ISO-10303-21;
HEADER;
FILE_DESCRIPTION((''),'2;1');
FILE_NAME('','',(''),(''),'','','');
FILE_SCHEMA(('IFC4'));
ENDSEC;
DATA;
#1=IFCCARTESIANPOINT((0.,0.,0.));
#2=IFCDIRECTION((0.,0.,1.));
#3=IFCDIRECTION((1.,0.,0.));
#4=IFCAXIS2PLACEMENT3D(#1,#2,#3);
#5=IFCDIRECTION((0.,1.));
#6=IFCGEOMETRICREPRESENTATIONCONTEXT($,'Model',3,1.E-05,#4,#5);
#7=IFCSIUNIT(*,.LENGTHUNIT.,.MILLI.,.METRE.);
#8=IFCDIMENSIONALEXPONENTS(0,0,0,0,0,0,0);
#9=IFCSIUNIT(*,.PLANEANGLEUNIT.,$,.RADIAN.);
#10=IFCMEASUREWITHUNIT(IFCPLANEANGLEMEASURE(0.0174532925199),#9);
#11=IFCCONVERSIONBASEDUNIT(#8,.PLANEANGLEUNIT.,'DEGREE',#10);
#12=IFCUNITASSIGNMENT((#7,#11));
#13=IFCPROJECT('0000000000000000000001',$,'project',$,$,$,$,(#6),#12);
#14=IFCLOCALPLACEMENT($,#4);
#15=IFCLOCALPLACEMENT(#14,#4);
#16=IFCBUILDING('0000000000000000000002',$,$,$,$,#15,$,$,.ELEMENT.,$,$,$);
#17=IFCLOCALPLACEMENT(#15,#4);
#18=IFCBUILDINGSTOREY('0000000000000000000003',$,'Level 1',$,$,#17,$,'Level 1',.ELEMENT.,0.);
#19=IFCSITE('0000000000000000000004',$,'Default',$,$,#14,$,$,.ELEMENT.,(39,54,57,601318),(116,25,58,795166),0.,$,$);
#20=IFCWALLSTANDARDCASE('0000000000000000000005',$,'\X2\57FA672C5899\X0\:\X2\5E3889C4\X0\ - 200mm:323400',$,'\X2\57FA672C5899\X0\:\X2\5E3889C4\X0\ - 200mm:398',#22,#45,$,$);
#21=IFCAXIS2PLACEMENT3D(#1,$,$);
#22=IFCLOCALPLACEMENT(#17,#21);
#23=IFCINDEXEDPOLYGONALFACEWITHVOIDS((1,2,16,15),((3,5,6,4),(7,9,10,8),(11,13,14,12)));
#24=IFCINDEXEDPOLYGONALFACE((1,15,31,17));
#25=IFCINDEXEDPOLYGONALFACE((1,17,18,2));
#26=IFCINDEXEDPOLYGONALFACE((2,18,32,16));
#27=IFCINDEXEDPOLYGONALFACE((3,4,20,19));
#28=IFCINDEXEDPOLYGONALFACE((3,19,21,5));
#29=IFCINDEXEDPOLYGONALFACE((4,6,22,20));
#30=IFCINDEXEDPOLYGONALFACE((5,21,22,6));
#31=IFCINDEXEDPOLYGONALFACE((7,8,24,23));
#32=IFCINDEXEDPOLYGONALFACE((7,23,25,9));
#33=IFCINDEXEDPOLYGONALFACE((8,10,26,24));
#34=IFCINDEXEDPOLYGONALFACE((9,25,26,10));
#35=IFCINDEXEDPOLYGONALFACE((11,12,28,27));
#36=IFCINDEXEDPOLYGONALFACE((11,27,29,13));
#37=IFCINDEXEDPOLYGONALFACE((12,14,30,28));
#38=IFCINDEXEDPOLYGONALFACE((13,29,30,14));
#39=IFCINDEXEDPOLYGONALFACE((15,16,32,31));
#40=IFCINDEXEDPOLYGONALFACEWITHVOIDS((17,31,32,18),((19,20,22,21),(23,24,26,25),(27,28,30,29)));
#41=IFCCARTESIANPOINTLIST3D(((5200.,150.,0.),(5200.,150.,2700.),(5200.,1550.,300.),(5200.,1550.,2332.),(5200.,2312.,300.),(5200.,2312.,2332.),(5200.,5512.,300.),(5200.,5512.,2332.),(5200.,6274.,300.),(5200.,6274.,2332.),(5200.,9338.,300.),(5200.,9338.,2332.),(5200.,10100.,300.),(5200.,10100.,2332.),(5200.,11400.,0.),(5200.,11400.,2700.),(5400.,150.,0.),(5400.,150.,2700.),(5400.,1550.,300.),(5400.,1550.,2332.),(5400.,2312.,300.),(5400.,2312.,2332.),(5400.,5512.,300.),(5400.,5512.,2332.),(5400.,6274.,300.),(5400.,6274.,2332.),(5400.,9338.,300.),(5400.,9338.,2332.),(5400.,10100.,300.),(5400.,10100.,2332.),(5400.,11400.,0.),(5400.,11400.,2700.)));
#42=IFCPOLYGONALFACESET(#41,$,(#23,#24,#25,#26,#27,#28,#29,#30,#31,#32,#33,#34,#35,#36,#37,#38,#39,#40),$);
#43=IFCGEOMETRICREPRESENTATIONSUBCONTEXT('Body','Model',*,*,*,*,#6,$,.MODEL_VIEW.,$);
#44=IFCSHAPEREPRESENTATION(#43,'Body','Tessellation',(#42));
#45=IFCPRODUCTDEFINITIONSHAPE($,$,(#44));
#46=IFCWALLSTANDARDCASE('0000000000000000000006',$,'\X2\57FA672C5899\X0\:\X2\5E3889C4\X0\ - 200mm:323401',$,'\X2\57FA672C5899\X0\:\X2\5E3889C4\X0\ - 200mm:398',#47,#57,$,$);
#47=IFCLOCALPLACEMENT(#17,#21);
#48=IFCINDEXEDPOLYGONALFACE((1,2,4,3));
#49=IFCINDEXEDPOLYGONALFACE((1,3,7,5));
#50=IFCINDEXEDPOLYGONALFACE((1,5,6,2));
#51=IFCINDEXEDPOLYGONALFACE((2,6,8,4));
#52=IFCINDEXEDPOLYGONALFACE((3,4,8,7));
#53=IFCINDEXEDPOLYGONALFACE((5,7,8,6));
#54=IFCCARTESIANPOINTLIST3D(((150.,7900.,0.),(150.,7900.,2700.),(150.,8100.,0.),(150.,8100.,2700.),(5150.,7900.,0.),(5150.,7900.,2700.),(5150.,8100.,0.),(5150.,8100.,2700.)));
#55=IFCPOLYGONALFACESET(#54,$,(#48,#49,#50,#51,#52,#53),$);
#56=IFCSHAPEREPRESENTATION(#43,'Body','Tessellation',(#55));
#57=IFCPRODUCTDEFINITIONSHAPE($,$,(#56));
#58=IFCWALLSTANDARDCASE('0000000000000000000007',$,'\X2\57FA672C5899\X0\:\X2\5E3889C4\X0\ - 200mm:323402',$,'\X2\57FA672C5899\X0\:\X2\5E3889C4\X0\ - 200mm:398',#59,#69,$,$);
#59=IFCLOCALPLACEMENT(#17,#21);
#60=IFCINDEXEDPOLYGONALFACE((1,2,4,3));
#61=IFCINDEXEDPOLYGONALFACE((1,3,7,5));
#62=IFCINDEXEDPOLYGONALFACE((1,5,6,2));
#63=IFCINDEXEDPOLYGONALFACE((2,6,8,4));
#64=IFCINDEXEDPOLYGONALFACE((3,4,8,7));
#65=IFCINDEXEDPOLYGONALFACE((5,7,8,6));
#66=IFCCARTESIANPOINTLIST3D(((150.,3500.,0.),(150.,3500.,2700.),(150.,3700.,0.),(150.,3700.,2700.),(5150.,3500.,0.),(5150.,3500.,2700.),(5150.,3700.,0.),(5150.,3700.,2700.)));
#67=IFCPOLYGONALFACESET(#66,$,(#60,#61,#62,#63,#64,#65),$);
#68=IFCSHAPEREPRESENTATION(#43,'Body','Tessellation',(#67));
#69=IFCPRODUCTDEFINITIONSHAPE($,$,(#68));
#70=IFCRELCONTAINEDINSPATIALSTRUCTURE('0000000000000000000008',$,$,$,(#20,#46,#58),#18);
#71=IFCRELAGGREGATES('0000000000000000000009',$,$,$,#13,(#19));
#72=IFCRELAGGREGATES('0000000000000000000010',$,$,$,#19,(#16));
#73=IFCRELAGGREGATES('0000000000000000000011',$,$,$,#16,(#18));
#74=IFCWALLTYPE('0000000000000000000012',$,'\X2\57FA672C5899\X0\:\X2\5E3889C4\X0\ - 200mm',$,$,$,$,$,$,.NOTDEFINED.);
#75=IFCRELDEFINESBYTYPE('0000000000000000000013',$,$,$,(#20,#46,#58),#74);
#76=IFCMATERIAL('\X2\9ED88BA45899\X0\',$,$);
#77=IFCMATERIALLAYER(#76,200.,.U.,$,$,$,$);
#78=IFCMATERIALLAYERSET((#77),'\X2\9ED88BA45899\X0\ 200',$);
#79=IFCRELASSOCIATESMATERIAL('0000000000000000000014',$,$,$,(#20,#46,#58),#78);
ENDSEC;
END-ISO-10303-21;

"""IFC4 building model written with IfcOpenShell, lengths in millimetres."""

from ifc_helpers import new_model, entity, si_unit, converted_unit, direction, frame, origin_with_axes, place, context, subcontext, project, spatial, polyline, outline, extrude, clip, halfspace, material, layer, layer_set, layer_usage, type_object, element, save


model = new_model("IFC4")

# Units and contexts
model_context = context("Model", 3, precision=1e-05, world=origin_with_axes(), true_north=direction((0.0, 1.0)))
body_context = subcontext(model_context, "Body", "Model", "MODEL_VIEW")
ifc_project = project(units=[si_unit("LENGTHUNIT", "METRE", prefix="MILLI"), converted_unit("PLANEANGLEUNIT", "DEGREE", entity("IfcPlaneAngleMeasure", 0.0174532925199), si_unit("PLANEANGLEUNIT", "RADIAN"), dimensions=[0, 0, 0, 0, 0, 0, 0])], contexts=[model_context])

# Site, building, storey
site_placement = place(None, origin_with_axes())
site = spatial("IfcSite", under=ifc_project, at=site_placement, Name="Default", CompositionType="ELEMENT", RefLatitude=(39, 54, 57, 601318), RefLongitude=(116, 25, 58, 795166), RefElevation=0.0)
building_placement = place(site_placement, origin_with_axes())
building = spatial("IfcBuilding", under=site, at=building_placement, CompositionType="ELEMENT")
storey_placement = place(building_placement, origin_with_axes())
storey = spatial("IfcBuildingStorey", under=building, at=storey_placement, Name="Level 1", LongName="Level 1", CompositionType="ELEMENT", Elevation=0.0)

# Shared definitions
ifc_material_1 = material(Name="默认墙")
ifc_layer_1 = layer(ifc_material_1, 200.0, ventilated="UNKNOWN")
ifc_layer_set_1 = layer_set([ifc_layer_1], Name="默认墙 200")
wall_type = type_object("IfcWallType", Name="基本墙:常规 - 200mm", PredefinedType="NOTDEFINED")

# Wall, openings
ifc_layer_usage_1 = layer_usage(ifc_layer_set_1, "AXIS2", "POSITIVE", -100.0)
wall_1_placement = place(storey_placement, frame((5300.0, 11500.0, 0.0), z_axis=(0.0, 0.0, 1.0), x_axis=(0.0, -1.0, 0.0)))
wall_1 = element("IfcWallStandardCase", 1, at=wall_1_placement, inside=storey, type_object=wall_type, material=ifc_layer_usage_1, Name="基本墙:常规 - 200mm:323400", ObjectType="基本墙:常规 - 200mm:398", context=body_context, shape_type="Clipping", body=[
    clip(extrude(outline(polyline([(100.0, -100.0), (11350.0, -100.0), (11350.0, 100.0), (100.0, 100.0), (100.0, -100.0)])), origin_with_axes(), (0.0, 0.0, 1.0), 2700.0), halfspace(frame((0.0, 0.0, 2700.0), z_axis=(0.0, 0.0, -1.0), x_axis=(0.0, 1.0, 0.0)), True)),
])
opening_1_placement = place(wall_1_placement, frame((9569.0, 0.0, 300.0), z_axis=(0.0, 0.0, 1.0), x_axis=(1.0, 0.0, 0.0)))
element("IfcOpeningElement", 2, at=opening_1_placement, cuts=wall_1, context=body_context, shape_type="SweptSolid", body=[
    extrude(outline(polyline([(-381.0, -2032.0), (381.0, -2032.0), (381.0, 0.0), (-381.0, 0.0), (-381.0, -2032.0)])), frame((0.0, -100.0, 0.0), z_axis=(0.0, 1.0, 0.0), x_axis=(1.0, 0.0, 0.0)), (0.0, 0.0, 1.0), 200.0),
])
opening_2_placement = place(wall_1_placement, frame((5607.0, 0.0, 300.0), z_axis=(0.0, 0.0, 1.0), x_axis=(1.0, 0.0, 0.0)))
element("IfcOpeningElement", 3, at=opening_2_placement, cuts=wall_1, context=body_context, shape_type="SweptSolid", body=[
    extrude(outline(polyline([(-381.0, -2032.0), (381.0, -2032.0), (381.0, 0.0), (-381.0, 0.0), (-381.0, -2032.0)])), frame((0.0, -100.0, 0.0), z_axis=(0.0, 1.0, 0.0), x_axis=(1.0, 0.0, 0.0)), (0.0, 0.0, 1.0), 200.0),
])
opening_3_placement = place(wall_1_placement, frame((1781.0, 0.0, 300.0), z_axis=(0.0, 0.0, 1.0), x_axis=(1.0, 0.0, 0.0)))
element("IfcOpeningElement", 4, at=opening_3_placement, cuts=wall_1, context=body_context, shape_type="SweptSolid", body=[
    extrude(outline(polyline([(-381.0, -2032.0), (381.0, -2032.0), (381.0, 0.0), (-381.0, 0.0), (-381.0, -2032.0)])), frame((0.0, -100.0, 0.0), z_axis=(0.0, 1.0, 0.0), x_axis=(1.0, 0.0, 0.0)), (0.0, 0.0, 1.0), 200.0),
])

# Walls
ifc_layer_usage_2 = layer_usage(ifc_layer_set_1, "AXIS2", "POSITIVE", -100.0)
wall_2_placement = place(storey_placement, frame((150.0, 8000.0, 0.0), z_axis=(0.0, 0.0, 1.0), x_axis=(1.0, 0.0, 0.0)))
element("IfcWallStandardCase", 5, at=wall_2_placement, inside=storey, type_object=wall_type, material=ifc_layer_usage_2, Name="基本墙:常规 - 200mm:323401", ObjectType="基本墙:常规 - 200mm:398", context=body_context, shape_type="Clipping", body=[
    clip(extrude(outline(polyline([(0.0, -100.0), (5000.0, -100.0), (5000.0, 100.0), (0.0, 100.0), (0.0, -100.0)])), origin_with_axes(), (0.0, 0.0, 1.0), 2700.0), halfspace(frame((0.0, 0.0, 2700.0), z_axis=(0.0, 0.0, -1.0), x_axis=(0.0, 1.0, 0.0)), True)),
])
ifc_layer_usage_3 = layer_usage(ifc_layer_set_1, "AXIS2", "POSITIVE", -100.0)
wall_3_placement = place(storey_placement, frame((150.0, 3600.0, 0.0), z_axis=(0.0, 0.0, 1.0), x_axis=(1.0, 0.0, 0.0)))
element("IfcWallStandardCase", 6, at=wall_3_placement, inside=storey, type_object=wall_type, material=ifc_layer_usage_3, Name="基本墙:常规 - 200mm:323402", ObjectType="基本墙:常规 - 200mm:398", context=body_context, shape_type="Clipping", body=[
    clip(extrude(outline(polyline([(0.0, -100.0), (5000.0, -100.0), (5000.0, 100.0), (0.0, 100.0), (0.0, -100.0)])), origin_with_axes(), (0.0, 0.0, 1.0), 2700.0), halfspace(frame((0.0, 0.0, 2700.0), z_axis=(0.0, 0.0, -1.0), x_axis=(0.0, 1.0, 0.0)), True)),
])

save(model, "model.ifc")
